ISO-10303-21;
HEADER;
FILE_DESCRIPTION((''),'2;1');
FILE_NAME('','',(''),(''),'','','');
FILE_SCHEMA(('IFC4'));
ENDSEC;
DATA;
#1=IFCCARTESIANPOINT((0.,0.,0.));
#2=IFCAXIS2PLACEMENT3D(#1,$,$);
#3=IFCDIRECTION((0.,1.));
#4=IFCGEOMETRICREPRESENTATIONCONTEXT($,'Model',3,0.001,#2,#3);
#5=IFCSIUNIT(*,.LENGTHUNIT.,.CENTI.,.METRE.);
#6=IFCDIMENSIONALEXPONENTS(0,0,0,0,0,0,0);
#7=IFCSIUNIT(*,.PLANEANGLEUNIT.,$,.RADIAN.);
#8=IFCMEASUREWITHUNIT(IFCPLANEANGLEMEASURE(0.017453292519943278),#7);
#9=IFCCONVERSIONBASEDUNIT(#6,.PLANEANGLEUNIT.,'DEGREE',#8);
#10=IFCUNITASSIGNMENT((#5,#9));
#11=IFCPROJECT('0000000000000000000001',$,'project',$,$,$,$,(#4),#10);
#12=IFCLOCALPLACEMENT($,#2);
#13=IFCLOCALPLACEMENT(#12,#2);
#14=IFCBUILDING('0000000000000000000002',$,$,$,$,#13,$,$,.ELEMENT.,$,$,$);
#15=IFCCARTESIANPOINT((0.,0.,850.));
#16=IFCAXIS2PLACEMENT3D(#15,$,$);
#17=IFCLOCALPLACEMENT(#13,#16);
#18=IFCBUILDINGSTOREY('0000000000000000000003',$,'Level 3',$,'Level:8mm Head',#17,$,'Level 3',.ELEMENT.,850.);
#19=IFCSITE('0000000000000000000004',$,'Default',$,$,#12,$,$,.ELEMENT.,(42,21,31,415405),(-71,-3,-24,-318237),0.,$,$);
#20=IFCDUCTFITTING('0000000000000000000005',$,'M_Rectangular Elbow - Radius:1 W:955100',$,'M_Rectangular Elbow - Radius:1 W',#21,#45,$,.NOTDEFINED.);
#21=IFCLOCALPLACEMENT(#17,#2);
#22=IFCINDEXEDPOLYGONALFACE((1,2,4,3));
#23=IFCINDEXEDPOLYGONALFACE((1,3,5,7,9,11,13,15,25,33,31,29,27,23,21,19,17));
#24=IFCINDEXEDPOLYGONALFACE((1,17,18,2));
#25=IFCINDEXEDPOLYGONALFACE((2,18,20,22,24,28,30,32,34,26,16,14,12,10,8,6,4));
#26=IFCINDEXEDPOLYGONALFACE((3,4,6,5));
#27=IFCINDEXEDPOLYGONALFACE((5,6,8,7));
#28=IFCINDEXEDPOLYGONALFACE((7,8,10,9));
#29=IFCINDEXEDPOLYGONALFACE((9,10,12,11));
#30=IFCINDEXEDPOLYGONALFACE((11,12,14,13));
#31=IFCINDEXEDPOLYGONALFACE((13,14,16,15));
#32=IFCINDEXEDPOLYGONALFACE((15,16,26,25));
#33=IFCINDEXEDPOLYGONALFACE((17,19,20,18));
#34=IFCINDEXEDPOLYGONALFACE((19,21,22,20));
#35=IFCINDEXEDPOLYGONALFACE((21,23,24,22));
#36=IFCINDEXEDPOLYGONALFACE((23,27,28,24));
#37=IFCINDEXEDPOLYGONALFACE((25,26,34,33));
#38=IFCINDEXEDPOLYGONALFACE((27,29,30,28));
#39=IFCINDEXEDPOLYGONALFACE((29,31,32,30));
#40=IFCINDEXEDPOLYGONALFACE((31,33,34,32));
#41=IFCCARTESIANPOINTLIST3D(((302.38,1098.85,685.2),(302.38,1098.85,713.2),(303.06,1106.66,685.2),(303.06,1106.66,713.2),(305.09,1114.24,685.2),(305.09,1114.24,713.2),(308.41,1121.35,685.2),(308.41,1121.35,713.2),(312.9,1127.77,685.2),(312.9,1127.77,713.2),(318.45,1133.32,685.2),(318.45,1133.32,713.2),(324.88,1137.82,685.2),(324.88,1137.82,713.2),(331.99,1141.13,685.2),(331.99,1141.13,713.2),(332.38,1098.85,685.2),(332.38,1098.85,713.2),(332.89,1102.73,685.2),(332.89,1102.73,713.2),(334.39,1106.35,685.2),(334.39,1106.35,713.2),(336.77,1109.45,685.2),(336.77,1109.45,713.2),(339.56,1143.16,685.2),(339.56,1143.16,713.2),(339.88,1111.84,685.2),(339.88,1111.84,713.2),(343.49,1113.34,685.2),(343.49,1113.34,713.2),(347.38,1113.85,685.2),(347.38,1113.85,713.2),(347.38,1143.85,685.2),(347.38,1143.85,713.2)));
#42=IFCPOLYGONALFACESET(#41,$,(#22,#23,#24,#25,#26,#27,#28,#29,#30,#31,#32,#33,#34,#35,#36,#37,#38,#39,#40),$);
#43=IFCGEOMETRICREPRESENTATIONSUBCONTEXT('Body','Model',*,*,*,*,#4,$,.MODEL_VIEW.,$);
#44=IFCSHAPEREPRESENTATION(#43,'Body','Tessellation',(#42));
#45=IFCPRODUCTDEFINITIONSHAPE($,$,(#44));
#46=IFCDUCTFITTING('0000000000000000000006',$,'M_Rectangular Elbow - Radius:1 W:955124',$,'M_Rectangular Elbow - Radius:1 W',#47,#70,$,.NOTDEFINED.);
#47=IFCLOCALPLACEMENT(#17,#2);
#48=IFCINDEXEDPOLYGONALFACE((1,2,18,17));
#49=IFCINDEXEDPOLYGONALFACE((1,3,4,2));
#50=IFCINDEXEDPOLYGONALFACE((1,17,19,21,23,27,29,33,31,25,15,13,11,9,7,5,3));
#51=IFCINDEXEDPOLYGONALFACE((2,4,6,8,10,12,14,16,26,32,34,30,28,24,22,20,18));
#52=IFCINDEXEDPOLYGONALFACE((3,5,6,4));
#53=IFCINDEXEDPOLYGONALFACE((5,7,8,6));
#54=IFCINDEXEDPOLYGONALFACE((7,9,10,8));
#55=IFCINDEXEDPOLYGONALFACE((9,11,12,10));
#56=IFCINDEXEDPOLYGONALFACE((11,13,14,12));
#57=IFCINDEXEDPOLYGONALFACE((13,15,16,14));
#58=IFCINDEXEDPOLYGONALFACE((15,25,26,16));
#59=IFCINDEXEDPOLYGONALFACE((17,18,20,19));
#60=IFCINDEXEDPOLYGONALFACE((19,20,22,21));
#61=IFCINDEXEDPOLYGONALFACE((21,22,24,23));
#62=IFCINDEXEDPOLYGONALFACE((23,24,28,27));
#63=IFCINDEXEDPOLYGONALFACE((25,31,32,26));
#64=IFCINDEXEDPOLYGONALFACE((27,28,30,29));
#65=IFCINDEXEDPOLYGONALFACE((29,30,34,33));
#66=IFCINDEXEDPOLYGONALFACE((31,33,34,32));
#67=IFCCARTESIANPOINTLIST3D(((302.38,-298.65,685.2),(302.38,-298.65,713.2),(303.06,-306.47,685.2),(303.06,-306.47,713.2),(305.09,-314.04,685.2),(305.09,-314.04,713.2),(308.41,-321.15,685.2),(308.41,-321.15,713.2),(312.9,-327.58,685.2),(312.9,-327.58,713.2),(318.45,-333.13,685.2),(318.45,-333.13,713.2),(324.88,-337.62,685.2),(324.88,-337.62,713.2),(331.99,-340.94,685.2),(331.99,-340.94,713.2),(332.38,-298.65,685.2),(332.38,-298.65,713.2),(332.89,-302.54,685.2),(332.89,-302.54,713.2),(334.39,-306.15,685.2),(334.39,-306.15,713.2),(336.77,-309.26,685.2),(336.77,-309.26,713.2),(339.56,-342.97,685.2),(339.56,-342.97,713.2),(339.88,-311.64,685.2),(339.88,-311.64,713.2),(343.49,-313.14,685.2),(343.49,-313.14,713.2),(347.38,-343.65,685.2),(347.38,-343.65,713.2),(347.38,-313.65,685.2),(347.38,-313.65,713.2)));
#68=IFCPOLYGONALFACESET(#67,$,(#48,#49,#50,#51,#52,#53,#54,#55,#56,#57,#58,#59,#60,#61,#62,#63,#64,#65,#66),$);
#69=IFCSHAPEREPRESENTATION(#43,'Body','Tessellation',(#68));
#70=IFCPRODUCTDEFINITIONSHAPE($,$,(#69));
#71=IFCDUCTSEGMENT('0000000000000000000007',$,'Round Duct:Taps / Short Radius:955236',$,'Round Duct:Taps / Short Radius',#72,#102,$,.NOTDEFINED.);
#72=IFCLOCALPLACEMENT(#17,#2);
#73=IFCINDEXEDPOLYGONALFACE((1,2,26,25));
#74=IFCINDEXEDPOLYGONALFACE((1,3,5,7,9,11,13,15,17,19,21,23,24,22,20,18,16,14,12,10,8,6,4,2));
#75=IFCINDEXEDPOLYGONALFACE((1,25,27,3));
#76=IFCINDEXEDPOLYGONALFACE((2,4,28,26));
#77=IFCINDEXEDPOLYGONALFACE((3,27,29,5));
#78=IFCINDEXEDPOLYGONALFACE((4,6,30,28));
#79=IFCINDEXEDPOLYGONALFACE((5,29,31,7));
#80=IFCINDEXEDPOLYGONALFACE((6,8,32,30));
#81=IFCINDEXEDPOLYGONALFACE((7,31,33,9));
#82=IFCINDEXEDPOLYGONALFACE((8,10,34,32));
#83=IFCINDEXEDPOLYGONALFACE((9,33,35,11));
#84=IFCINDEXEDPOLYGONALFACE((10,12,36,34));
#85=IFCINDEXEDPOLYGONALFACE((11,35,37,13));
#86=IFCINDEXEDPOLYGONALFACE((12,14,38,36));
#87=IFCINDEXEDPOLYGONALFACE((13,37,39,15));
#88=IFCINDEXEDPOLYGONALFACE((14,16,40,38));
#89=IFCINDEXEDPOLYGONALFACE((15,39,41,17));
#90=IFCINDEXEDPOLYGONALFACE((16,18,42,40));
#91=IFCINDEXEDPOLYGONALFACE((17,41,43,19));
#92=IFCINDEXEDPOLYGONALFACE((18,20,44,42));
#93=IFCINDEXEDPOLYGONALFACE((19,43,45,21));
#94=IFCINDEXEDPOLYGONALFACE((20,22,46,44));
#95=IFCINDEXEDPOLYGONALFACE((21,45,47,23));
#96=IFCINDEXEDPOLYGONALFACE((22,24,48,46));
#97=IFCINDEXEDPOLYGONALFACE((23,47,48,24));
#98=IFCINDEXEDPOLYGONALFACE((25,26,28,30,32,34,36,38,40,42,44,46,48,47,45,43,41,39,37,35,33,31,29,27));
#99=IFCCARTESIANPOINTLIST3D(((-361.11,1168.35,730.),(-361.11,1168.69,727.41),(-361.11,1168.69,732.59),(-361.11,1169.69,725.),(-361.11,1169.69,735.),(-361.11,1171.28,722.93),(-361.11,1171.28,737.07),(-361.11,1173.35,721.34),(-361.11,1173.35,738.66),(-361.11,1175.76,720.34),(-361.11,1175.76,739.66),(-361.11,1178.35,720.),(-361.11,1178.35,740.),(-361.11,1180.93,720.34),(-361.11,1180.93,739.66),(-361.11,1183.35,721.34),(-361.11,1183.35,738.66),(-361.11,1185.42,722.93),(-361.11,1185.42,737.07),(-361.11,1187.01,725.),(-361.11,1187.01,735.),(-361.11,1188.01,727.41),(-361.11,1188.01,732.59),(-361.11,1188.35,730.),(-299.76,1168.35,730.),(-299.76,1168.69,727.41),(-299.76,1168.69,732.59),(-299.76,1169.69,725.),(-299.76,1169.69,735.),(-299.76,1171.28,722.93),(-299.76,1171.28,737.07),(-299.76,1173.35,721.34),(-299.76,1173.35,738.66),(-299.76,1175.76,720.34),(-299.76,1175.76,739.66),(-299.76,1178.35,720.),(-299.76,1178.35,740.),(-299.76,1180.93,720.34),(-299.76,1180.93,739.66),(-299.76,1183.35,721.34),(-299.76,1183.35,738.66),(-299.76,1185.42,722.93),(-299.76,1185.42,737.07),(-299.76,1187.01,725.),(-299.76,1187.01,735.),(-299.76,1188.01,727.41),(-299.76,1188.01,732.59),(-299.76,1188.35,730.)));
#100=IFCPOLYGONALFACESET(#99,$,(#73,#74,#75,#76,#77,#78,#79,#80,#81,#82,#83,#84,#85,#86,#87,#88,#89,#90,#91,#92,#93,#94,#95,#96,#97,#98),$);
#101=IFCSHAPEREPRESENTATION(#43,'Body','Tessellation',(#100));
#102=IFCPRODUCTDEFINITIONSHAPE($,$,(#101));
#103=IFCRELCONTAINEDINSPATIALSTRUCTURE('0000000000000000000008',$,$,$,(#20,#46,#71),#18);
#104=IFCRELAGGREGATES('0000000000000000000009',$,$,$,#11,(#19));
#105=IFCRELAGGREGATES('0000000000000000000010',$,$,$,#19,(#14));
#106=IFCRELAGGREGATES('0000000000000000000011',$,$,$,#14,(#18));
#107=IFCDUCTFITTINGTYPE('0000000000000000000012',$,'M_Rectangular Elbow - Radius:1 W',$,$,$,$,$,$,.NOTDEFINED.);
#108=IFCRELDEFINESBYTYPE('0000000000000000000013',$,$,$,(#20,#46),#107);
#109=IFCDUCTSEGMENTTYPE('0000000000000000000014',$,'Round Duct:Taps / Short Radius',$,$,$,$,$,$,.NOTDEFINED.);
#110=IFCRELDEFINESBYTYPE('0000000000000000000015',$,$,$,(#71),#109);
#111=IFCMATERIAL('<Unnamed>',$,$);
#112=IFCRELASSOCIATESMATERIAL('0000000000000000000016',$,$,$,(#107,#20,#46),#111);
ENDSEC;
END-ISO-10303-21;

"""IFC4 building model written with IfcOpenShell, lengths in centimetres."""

from ifc_helpers import new_model, entity, si_unit, converted_unit, direction, frame, origin, place, context, subcontext, project, spatial, line, arc, indexed_curve, outline, extrude, source, transform, mapped, material, type_object, type_shapes, element, save


model = new_model("IFC4")

# Units and contexts
model_context = context("Model", 3, precision=0.001, world=origin(), true_north=direction((0.0, 1.0)))
body_context = subcontext(model_context, "Body", "Model", "MODEL_VIEW")
ifc_project = project(units=[si_unit("LENGTHUNIT", "METRE", prefix="CENTI"), converted_unit("PLANEANGLEUNIT", "DEGREE", entity("IfcPlaneAngleMeasure", 0.017453292519943278), si_unit("PLANEANGLEUNIT", "RADIAN"), dimensions=[0, 0, 0, 0, 0, 0, 0])], contexts=[model_context])

# Site, building, storey
site_placement = place(None, origin())
site = spatial("IfcSite", under=ifc_project, at=site_placement, Name="Default", CompositionType="ELEMENT", RefLatitude=(42, 21, 31, 415405), RefLongitude=(-71, -3, -24, -318237), RefElevation=0.0)
building_placement = place(site_placement, origin())
building = spatial("IfcBuilding", under=site, at=building_placement, CompositionType="ELEMENT")
storey_placement = place(building_placement, frame((0.0, 0.0, 850.0)))
storey = spatial("IfcBuildingStorey", under=building, at=storey_placement, Name="Level 3", ObjectType="Level:8mm Head", LongName="Level 3", CompositionType="ELEMENT", Elevation=850.0)

# Duct fittings
ifc_material = material(Name="<Unnamed>")
duct_fitting_type_1 = type_object("IfcDuctFittingType", Name="M_Rectangular Elbow - Radius:1 W", PredefinedType="NOTDEFINED", material=ifc_material)
shared_shape_1 = source(origin(), body_context, "Body", "SweptSolid", [
    extrude(outline(indexed_curve([(-15.0, -30.0), (16.82, -16.82), (30.0, 15.0), (0.0, 15.0), (-4.39, 4.39), (-15.0, 0.0)], segments=[arc(1, 2, 3), line(3, 4), arc(4, 5, 6), line(6, 1)], self_intersect=False)), frame((-15.0, -15.0, -14.0), z_axis=(0.0, 0.0, 1.0), x_axis=(0.0, 1.0, 0.0)), (0.0, 0.0, 1.0), 28.0),
])
type_shapes(duct_fitting_type_1, [shared_shape_1])
for number, where, z_axis, x_axis, name in (
    (1, (317.38, 1128.85, 699.2), (0.0, 0.0, 1.0), (0.0, 1.0, 0.0), "M_Rectangular Elbow - Radius:1 W:955100"),
    (2, (317.38, -328.65, 699.2), (0.0, 0.0, 1.0), (-1.0, 0.0, 0.0), "M_Rectangular Elbow - Radius:1 W:955124"),
):
    element("IfcDuctFitting", number, at=place(storey_placement, frame(where, z_axis=z_axis, x_axis=x_axis)), inside=storey, type_object=duct_fitting_type_1, material=ifc_material, Name=name, ObjectType="M_Rectangular Elbow - Radius:1 W", PredefinedType="NOTDEFINED", context=body_context, shape_type="MappedRepresentation", body=[
        mapped(shared_shape_1, transform((0.0, 0.0, 0.0), scale=1.0)),
    ])

# Duct segment
duct_segment_type_1 = type_object("IfcDuctSegmentType", Name="Round Duct:Taps / Short Radius", PredefinedType="NOTDEFINED")
duct_segment_1_placement = place(storey_placement, origin())
element("IfcDuctSegment", 3, at=duct_segment_1_placement, inside=storey, type_object=duct_segment_type_1, Name="Round Duct:Taps / Short Radius:955236", ObjectType="Round Duct:Taps / Short Radius", PredefinedType="NOTDEFINED", context=body_context, shape_type="SweptSolid", body=[
    extrude(outline(indexed_curve([(10.0, 0.0), (7.07, 7.07), (0.0, 10.0), (-7.07, 7.07), (-10.0, 0.0), (-7.07, -7.07), (0.0, -10.0), (7.07, -7.07)], segments=[arc(1, 2, 3), arc(3, 4, 5), arc(5, 6, 7), arc(7, 8, 1)], self_intersect=False)), frame((-361.11, 1178.35, 730.0), z_axis=(1.0, 0.0, 0.0), x_axis=(0.0, 1.0, 0.0)), (0.0, 0.0, 1.0), 61.35),
])

save(model, "model.ifc")
